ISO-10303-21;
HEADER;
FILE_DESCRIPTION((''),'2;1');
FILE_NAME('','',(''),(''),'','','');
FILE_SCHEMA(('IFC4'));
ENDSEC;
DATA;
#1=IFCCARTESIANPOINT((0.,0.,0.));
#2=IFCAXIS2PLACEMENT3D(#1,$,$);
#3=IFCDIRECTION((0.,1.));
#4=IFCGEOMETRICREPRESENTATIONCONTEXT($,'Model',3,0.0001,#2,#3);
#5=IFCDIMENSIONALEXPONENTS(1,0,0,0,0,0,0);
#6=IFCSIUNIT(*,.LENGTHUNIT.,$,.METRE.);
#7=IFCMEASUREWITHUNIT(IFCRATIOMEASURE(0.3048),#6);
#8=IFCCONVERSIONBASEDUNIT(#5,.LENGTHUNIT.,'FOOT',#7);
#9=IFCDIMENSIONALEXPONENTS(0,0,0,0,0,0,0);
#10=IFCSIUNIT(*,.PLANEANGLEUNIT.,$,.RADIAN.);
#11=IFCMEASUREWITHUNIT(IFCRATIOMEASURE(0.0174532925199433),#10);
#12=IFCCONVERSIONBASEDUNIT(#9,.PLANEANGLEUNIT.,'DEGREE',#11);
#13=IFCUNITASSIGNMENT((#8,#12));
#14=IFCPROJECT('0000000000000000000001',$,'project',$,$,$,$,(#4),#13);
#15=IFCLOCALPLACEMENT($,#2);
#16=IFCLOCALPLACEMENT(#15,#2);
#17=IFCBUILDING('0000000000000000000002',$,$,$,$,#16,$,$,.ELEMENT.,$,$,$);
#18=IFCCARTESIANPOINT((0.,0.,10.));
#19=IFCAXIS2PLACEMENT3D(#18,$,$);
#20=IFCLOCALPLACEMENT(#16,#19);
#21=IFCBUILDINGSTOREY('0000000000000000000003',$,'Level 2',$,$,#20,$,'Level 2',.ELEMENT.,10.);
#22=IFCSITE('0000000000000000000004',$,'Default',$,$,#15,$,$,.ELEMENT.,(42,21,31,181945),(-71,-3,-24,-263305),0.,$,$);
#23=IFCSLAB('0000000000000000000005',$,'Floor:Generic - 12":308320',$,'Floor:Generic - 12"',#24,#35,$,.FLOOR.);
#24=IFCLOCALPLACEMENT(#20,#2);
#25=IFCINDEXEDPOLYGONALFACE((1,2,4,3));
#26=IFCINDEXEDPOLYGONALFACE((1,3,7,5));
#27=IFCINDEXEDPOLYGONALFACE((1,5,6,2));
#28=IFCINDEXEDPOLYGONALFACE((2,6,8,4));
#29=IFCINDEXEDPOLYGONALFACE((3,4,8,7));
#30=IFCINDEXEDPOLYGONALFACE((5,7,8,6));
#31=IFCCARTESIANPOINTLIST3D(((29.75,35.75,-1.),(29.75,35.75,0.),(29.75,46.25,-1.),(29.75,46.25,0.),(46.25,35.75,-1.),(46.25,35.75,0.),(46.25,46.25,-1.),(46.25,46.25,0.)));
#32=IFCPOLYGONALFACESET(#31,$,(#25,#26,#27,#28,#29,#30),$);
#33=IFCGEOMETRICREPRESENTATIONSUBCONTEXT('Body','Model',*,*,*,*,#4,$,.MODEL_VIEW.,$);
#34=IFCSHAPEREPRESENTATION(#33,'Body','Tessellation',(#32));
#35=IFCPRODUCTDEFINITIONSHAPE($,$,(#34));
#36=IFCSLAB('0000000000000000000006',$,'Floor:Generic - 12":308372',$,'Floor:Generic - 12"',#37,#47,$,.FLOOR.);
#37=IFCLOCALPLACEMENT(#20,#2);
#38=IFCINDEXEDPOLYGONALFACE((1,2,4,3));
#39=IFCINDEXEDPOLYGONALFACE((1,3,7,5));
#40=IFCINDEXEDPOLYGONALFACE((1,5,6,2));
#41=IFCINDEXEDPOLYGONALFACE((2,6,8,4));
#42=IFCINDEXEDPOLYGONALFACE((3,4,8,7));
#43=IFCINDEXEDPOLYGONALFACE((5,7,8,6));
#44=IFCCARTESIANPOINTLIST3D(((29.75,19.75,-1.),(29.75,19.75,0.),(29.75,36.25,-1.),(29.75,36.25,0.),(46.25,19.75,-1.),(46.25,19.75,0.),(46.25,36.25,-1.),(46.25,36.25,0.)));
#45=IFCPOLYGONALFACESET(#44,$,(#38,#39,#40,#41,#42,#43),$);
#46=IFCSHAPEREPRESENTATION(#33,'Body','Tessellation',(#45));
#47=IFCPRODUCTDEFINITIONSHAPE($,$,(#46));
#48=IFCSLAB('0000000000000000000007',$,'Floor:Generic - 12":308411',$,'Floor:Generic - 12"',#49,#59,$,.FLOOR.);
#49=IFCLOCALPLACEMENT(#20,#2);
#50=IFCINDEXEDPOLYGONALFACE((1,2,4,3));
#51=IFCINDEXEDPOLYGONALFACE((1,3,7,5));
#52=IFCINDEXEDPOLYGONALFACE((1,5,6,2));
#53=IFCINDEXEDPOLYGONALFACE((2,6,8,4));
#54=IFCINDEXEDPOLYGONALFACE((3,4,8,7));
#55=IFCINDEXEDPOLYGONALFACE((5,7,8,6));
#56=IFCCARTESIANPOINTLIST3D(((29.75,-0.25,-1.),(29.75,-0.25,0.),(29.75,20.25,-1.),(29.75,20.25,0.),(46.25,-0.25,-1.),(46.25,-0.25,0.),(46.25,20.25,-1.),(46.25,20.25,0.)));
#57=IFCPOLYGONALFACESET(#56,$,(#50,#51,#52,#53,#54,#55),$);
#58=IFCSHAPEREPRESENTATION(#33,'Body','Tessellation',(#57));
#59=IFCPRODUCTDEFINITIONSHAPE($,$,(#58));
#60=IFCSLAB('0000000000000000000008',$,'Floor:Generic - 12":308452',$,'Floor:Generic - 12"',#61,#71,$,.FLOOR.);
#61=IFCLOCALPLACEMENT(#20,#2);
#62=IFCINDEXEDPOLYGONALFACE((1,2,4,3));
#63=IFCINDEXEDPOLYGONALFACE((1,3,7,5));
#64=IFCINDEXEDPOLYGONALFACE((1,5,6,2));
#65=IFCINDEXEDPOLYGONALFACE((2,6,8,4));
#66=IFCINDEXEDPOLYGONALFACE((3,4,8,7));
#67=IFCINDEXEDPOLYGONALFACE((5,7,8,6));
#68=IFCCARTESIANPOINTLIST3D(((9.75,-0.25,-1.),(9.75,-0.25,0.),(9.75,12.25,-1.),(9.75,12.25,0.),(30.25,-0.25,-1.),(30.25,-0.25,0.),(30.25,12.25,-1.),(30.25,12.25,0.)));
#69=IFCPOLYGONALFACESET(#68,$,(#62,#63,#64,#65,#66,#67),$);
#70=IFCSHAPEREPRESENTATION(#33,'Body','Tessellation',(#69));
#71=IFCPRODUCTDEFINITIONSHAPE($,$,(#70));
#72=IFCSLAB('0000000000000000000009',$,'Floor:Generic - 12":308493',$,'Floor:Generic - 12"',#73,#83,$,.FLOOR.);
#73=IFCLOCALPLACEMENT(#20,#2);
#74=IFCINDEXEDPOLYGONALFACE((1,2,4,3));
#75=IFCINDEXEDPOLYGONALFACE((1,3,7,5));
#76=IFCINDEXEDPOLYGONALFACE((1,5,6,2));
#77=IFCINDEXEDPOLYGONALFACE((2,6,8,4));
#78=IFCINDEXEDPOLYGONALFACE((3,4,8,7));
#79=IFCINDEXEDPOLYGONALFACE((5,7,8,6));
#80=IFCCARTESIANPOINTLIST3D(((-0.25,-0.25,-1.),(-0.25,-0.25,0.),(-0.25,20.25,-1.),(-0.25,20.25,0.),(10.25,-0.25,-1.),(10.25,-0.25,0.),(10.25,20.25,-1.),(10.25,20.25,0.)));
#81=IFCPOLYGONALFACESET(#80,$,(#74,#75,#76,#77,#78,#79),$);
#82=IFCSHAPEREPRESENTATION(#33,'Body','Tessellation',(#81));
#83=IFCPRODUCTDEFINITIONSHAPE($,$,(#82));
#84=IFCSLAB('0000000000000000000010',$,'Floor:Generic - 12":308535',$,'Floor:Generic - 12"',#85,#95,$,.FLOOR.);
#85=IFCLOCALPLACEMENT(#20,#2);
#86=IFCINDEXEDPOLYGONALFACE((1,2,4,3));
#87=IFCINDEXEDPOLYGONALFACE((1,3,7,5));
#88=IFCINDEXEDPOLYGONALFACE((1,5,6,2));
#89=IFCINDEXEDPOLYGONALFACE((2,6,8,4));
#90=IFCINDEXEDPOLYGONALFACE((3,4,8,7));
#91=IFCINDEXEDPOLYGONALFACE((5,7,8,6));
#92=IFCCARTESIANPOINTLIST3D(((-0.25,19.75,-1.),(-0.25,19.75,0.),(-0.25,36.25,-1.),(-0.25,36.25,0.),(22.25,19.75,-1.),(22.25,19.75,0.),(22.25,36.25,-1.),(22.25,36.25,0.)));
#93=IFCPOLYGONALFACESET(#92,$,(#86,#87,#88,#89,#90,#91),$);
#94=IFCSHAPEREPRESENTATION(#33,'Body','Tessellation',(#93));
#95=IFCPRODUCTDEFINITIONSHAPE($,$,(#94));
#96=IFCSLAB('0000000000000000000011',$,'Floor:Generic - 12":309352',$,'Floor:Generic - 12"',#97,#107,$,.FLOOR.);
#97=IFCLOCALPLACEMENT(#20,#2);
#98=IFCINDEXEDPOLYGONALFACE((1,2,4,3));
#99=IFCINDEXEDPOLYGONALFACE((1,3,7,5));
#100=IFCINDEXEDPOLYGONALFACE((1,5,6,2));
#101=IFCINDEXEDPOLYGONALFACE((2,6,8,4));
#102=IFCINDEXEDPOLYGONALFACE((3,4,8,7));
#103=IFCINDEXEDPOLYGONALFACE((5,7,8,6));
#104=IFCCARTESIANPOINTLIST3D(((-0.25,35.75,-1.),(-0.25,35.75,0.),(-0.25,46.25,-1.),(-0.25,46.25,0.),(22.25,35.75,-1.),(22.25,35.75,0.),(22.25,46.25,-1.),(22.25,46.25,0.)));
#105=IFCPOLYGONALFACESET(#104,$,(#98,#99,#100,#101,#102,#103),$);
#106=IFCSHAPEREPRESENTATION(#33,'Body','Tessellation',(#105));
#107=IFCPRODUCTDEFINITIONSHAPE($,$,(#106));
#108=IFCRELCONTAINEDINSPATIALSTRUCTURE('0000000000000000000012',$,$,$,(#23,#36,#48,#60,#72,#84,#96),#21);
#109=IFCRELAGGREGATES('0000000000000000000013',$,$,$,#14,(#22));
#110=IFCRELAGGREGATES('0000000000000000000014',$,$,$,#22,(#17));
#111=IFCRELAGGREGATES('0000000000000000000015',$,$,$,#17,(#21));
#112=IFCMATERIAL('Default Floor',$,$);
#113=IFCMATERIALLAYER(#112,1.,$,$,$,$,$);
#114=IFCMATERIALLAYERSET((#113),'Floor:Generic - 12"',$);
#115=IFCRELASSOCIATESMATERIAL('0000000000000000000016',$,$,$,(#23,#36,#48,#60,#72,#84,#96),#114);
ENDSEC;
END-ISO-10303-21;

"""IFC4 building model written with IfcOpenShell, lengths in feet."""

from ifc_helpers import new_model, entity, si_unit, converted_unit, direction, frame, frame_2d, origin, place, context, subcontext, project, spatial, rectangle, extrude, material, layer, layer_set, layer_usage, element, save


model = new_model("IFC4")

# Units and contexts
model_context = context("Model", 3, precision=0.0001, world=origin(), true_north=direction((0.0, 1.0)))
body_context = subcontext(model_context, "Body", "Model", "MODEL_VIEW")
ifc_project = project(units=[converted_unit("LENGTHUNIT", "FOOT", entity("IfcRatioMeasure", 0.3048), si_unit("LENGTHUNIT", "METRE"), dimensions=[1, 0, 0, 0, 0, 0, 0]), converted_unit("PLANEANGLEUNIT", "DEGREE", entity("IfcRatioMeasure", 0.0174532925199433), si_unit("PLANEANGLEUNIT", "RADIAN"), dimensions=[0, 0, 0, 0, 0, 0, 0])], contexts=[model_context])

# Site, building, storey
site_placement = place(None, origin())
site = spatial("IfcSite", under=ifc_project, at=site_placement, Name="Default", CompositionType="ELEMENT", RefLatitude=(42, 21, 31, 181945), RefLongitude=(-71, -3, -24, -263305), RefElevation=0.0)
building_placement = place(site_placement, origin())
building = spatial("IfcBuilding", under=site, at=building_placement, CompositionType="ELEMENT")
storey_placement = place(building_placement, frame((0.0, 0.0, 10.0)))
storey = spatial("IfcBuildingStorey", under=building, at=storey_placement, Name="Level 2", LongName="Level 2", CompositionType="ELEMENT", Elevation=10.0)

# Slabs
ifc_material = material(Name="Default Floor")
ifc_layer = layer(ifc_material, 1.0)
ifc_layer_set = layer_set([ifc_layer], Name="Floor:Generic - 12\"")
ifc_layer_usage_1 = layer_usage(ifc_layer_set, "AXIS3", "POSITIVE", 0.0)
slab_1_placement = place(storey_placement, origin())
element("IfcSlab", 1, at=slab_1_placement, inside=storey, material=ifc_layer_usage_1, Name="Floor:Generic - 12\":308320", ObjectType="Floor:Generic - 12\"", PredefinedType="FLOOR", context=body_context, shape_type="SweptSolid", body=[
    extrude(rectangle(XDim=10.5, YDim=16.5, at=frame_2d((0.0, 0.0), x_axis=(1.0, 0.0))), frame((38.0, 41.0, 0.0), z_axis=(0.0, 0.0, -1.0), x_axis=(0.0, 1.0, 0.0)), (0.0, 0.0, 1.0), 1.0),
])
ifc_layer_usage_2 = layer_usage(ifc_layer_set, "AXIS3", "POSITIVE", 0.0)
slab_2_placement = place(storey_placement, origin())
element("IfcSlab", 2, at=slab_2_placement, inside=storey, material=ifc_layer_usage_2, Name="Floor:Generic - 12\":308372", ObjectType="Floor:Generic - 12\"", PredefinedType="FLOOR", context=body_context, shape_type="SweptSolid", body=[
    extrude(rectangle(XDim=16.5, YDim=16.5, at=frame_2d((0.0, 0.0), x_axis=(1.0, 0.0))), frame((38.0, 28.0, 0.0), z_axis=(0.0, 0.0, -1.0), x_axis=(0.0, 1.0, 0.0)), (0.0, 0.0, 1.0), 1.0),
])
ifc_layer_usage_3 = layer_usage(ifc_layer_set, "AXIS3", "POSITIVE", 0.0)
slab_3_placement = place(storey_placement, origin())
element("IfcSlab", 3, at=slab_3_placement, inside=storey, material=ifc_layer_usage_3, Name="Floor:Generic - 12\":308411", ObjectType="Floor:Generic - 12\"", PredefinedType="FLOOR", context=body_context, shape_type="SweptSolid", body=[
    extrude(rectangle(XDim=20.5, YDim=16.5, at=frame_2d((0.0, 0.0), x_axis=(1.0, 0.0))), frame((38.0, 10.0, 0.0), z_axis=(0.0, 0.0, -1.0), x_axis=(0.0, 1.0, 0.0)), (0.0, 0.0, 1.0), 1.0),
])
ifc_layer_usage_4 = layer_usage(ifc_layer_set, "AXIS3", "POSITIVE", 0.0)
slab_4_placement = place(storey_placement, origin())
element("IfcSlab", 4, at=slab_4_placement, inside=storey, material=ifc_layer_usage_4, Name="Floor:Generic - 12\":308452", ObjectType="Floor:Generic - 12\"", PredefinedType="FLOOR", context=body_context, shape_type="SweptSolid", body=[
    extrude(rectangle(XDim=12.5, YDim=20.5, at=frame_2d((0.0, 0.0), x_axis=(1.0, 0.0))), frame((20.0, 6.0, 0.0), z_axis=(0.0, 0.0, -1.0), x_axis=(0.0, 1.0, 0.0)), (0.0, 0.0, 1.0), 1.0),
])
ifc_layer_usage_5 = layer_usage(ifc_layer_set, "AXIS3", "POSITIVE", 0.0)
slab_5_placement = place(storey_placement, origin())
element("IfcSlab", 5, at=slab_5_placement, inside=storey, material=ifc_layer_usage_5, Name="Floor:Generic - 12\":308493", ObjectType="Floor:Generic - 12\"", PredefinedType="FLOOR", context=body_context, shape_type="SweptSolid", body=[
    extrude(rectangle(XDim=20.5, YDim=10.5, at=frame_2d((0.0, 0.0), x_axis=(1.0, 0.0))), frame((5.0, 10.0, 0.0), z_axis=(0.0, 0.0, -1.0), x_axis=(0.0, 1.0, 0.0)), (0.0, 0.0, 1.0), 1.0),
])
ifc_layer_usage_6 = layer_usage(ifc_layer_set, "AXIS3", "POSITIVE", 0.0)
slab_6_placement = place(storey_placement, origin())
element("IfcSlab", 6, at=slab_6_placement, inside=storey, material=ifc_layer_usage_6, Name="Floor:Generic - 12\":308535", ObjectType="Floor:Generic - 12\"", PredefinedType="FLOOR", context=body_context, shape_type="SweptSolid", body=[
    extrude(rectangle(XDim=16.5, YDim=22.5, at=frame_2d((0.0, 0.0), x_axis=(1.0, 0.0))), frame((11.0, 28.0, 0.0), z_axis=(0.0, 0.0, -1.0), x_axis=(0.0, 1.0, 0.0)), (0.0, 0.0, 1.0), 1.0),
])
ifc_layer_usage_7 = layer_usage(ifc_layer_set, "AXIS3", "POSITIVE", 0.0)
slab_7_placement = place(storey_placement, origin())
element("IfcSlab", 7, at=slab_7_placement, inside=storey, material=ifc_layer_usage_7, Name="Floor:Generic - 12\":309352", ObjectType="Floor:Generic - 12\"", PredefinedType="FLOOR", context=body_context, shape_type="SweptSolid", body=[
    extrude(rectangle(XDim=10.5, YDim=22.5, at=frame_2d((0.0, 0.0), x_axis=(1.0, 0.0))), frame((11.0, 41.0, 0.0), z_axis=(0.0, 0.0, -1.0), x_axis=(0.0, 1.0, 0.0)), (0.0, 0.0, 1.0), 1.0),
])

save(model, "model.ifc")
